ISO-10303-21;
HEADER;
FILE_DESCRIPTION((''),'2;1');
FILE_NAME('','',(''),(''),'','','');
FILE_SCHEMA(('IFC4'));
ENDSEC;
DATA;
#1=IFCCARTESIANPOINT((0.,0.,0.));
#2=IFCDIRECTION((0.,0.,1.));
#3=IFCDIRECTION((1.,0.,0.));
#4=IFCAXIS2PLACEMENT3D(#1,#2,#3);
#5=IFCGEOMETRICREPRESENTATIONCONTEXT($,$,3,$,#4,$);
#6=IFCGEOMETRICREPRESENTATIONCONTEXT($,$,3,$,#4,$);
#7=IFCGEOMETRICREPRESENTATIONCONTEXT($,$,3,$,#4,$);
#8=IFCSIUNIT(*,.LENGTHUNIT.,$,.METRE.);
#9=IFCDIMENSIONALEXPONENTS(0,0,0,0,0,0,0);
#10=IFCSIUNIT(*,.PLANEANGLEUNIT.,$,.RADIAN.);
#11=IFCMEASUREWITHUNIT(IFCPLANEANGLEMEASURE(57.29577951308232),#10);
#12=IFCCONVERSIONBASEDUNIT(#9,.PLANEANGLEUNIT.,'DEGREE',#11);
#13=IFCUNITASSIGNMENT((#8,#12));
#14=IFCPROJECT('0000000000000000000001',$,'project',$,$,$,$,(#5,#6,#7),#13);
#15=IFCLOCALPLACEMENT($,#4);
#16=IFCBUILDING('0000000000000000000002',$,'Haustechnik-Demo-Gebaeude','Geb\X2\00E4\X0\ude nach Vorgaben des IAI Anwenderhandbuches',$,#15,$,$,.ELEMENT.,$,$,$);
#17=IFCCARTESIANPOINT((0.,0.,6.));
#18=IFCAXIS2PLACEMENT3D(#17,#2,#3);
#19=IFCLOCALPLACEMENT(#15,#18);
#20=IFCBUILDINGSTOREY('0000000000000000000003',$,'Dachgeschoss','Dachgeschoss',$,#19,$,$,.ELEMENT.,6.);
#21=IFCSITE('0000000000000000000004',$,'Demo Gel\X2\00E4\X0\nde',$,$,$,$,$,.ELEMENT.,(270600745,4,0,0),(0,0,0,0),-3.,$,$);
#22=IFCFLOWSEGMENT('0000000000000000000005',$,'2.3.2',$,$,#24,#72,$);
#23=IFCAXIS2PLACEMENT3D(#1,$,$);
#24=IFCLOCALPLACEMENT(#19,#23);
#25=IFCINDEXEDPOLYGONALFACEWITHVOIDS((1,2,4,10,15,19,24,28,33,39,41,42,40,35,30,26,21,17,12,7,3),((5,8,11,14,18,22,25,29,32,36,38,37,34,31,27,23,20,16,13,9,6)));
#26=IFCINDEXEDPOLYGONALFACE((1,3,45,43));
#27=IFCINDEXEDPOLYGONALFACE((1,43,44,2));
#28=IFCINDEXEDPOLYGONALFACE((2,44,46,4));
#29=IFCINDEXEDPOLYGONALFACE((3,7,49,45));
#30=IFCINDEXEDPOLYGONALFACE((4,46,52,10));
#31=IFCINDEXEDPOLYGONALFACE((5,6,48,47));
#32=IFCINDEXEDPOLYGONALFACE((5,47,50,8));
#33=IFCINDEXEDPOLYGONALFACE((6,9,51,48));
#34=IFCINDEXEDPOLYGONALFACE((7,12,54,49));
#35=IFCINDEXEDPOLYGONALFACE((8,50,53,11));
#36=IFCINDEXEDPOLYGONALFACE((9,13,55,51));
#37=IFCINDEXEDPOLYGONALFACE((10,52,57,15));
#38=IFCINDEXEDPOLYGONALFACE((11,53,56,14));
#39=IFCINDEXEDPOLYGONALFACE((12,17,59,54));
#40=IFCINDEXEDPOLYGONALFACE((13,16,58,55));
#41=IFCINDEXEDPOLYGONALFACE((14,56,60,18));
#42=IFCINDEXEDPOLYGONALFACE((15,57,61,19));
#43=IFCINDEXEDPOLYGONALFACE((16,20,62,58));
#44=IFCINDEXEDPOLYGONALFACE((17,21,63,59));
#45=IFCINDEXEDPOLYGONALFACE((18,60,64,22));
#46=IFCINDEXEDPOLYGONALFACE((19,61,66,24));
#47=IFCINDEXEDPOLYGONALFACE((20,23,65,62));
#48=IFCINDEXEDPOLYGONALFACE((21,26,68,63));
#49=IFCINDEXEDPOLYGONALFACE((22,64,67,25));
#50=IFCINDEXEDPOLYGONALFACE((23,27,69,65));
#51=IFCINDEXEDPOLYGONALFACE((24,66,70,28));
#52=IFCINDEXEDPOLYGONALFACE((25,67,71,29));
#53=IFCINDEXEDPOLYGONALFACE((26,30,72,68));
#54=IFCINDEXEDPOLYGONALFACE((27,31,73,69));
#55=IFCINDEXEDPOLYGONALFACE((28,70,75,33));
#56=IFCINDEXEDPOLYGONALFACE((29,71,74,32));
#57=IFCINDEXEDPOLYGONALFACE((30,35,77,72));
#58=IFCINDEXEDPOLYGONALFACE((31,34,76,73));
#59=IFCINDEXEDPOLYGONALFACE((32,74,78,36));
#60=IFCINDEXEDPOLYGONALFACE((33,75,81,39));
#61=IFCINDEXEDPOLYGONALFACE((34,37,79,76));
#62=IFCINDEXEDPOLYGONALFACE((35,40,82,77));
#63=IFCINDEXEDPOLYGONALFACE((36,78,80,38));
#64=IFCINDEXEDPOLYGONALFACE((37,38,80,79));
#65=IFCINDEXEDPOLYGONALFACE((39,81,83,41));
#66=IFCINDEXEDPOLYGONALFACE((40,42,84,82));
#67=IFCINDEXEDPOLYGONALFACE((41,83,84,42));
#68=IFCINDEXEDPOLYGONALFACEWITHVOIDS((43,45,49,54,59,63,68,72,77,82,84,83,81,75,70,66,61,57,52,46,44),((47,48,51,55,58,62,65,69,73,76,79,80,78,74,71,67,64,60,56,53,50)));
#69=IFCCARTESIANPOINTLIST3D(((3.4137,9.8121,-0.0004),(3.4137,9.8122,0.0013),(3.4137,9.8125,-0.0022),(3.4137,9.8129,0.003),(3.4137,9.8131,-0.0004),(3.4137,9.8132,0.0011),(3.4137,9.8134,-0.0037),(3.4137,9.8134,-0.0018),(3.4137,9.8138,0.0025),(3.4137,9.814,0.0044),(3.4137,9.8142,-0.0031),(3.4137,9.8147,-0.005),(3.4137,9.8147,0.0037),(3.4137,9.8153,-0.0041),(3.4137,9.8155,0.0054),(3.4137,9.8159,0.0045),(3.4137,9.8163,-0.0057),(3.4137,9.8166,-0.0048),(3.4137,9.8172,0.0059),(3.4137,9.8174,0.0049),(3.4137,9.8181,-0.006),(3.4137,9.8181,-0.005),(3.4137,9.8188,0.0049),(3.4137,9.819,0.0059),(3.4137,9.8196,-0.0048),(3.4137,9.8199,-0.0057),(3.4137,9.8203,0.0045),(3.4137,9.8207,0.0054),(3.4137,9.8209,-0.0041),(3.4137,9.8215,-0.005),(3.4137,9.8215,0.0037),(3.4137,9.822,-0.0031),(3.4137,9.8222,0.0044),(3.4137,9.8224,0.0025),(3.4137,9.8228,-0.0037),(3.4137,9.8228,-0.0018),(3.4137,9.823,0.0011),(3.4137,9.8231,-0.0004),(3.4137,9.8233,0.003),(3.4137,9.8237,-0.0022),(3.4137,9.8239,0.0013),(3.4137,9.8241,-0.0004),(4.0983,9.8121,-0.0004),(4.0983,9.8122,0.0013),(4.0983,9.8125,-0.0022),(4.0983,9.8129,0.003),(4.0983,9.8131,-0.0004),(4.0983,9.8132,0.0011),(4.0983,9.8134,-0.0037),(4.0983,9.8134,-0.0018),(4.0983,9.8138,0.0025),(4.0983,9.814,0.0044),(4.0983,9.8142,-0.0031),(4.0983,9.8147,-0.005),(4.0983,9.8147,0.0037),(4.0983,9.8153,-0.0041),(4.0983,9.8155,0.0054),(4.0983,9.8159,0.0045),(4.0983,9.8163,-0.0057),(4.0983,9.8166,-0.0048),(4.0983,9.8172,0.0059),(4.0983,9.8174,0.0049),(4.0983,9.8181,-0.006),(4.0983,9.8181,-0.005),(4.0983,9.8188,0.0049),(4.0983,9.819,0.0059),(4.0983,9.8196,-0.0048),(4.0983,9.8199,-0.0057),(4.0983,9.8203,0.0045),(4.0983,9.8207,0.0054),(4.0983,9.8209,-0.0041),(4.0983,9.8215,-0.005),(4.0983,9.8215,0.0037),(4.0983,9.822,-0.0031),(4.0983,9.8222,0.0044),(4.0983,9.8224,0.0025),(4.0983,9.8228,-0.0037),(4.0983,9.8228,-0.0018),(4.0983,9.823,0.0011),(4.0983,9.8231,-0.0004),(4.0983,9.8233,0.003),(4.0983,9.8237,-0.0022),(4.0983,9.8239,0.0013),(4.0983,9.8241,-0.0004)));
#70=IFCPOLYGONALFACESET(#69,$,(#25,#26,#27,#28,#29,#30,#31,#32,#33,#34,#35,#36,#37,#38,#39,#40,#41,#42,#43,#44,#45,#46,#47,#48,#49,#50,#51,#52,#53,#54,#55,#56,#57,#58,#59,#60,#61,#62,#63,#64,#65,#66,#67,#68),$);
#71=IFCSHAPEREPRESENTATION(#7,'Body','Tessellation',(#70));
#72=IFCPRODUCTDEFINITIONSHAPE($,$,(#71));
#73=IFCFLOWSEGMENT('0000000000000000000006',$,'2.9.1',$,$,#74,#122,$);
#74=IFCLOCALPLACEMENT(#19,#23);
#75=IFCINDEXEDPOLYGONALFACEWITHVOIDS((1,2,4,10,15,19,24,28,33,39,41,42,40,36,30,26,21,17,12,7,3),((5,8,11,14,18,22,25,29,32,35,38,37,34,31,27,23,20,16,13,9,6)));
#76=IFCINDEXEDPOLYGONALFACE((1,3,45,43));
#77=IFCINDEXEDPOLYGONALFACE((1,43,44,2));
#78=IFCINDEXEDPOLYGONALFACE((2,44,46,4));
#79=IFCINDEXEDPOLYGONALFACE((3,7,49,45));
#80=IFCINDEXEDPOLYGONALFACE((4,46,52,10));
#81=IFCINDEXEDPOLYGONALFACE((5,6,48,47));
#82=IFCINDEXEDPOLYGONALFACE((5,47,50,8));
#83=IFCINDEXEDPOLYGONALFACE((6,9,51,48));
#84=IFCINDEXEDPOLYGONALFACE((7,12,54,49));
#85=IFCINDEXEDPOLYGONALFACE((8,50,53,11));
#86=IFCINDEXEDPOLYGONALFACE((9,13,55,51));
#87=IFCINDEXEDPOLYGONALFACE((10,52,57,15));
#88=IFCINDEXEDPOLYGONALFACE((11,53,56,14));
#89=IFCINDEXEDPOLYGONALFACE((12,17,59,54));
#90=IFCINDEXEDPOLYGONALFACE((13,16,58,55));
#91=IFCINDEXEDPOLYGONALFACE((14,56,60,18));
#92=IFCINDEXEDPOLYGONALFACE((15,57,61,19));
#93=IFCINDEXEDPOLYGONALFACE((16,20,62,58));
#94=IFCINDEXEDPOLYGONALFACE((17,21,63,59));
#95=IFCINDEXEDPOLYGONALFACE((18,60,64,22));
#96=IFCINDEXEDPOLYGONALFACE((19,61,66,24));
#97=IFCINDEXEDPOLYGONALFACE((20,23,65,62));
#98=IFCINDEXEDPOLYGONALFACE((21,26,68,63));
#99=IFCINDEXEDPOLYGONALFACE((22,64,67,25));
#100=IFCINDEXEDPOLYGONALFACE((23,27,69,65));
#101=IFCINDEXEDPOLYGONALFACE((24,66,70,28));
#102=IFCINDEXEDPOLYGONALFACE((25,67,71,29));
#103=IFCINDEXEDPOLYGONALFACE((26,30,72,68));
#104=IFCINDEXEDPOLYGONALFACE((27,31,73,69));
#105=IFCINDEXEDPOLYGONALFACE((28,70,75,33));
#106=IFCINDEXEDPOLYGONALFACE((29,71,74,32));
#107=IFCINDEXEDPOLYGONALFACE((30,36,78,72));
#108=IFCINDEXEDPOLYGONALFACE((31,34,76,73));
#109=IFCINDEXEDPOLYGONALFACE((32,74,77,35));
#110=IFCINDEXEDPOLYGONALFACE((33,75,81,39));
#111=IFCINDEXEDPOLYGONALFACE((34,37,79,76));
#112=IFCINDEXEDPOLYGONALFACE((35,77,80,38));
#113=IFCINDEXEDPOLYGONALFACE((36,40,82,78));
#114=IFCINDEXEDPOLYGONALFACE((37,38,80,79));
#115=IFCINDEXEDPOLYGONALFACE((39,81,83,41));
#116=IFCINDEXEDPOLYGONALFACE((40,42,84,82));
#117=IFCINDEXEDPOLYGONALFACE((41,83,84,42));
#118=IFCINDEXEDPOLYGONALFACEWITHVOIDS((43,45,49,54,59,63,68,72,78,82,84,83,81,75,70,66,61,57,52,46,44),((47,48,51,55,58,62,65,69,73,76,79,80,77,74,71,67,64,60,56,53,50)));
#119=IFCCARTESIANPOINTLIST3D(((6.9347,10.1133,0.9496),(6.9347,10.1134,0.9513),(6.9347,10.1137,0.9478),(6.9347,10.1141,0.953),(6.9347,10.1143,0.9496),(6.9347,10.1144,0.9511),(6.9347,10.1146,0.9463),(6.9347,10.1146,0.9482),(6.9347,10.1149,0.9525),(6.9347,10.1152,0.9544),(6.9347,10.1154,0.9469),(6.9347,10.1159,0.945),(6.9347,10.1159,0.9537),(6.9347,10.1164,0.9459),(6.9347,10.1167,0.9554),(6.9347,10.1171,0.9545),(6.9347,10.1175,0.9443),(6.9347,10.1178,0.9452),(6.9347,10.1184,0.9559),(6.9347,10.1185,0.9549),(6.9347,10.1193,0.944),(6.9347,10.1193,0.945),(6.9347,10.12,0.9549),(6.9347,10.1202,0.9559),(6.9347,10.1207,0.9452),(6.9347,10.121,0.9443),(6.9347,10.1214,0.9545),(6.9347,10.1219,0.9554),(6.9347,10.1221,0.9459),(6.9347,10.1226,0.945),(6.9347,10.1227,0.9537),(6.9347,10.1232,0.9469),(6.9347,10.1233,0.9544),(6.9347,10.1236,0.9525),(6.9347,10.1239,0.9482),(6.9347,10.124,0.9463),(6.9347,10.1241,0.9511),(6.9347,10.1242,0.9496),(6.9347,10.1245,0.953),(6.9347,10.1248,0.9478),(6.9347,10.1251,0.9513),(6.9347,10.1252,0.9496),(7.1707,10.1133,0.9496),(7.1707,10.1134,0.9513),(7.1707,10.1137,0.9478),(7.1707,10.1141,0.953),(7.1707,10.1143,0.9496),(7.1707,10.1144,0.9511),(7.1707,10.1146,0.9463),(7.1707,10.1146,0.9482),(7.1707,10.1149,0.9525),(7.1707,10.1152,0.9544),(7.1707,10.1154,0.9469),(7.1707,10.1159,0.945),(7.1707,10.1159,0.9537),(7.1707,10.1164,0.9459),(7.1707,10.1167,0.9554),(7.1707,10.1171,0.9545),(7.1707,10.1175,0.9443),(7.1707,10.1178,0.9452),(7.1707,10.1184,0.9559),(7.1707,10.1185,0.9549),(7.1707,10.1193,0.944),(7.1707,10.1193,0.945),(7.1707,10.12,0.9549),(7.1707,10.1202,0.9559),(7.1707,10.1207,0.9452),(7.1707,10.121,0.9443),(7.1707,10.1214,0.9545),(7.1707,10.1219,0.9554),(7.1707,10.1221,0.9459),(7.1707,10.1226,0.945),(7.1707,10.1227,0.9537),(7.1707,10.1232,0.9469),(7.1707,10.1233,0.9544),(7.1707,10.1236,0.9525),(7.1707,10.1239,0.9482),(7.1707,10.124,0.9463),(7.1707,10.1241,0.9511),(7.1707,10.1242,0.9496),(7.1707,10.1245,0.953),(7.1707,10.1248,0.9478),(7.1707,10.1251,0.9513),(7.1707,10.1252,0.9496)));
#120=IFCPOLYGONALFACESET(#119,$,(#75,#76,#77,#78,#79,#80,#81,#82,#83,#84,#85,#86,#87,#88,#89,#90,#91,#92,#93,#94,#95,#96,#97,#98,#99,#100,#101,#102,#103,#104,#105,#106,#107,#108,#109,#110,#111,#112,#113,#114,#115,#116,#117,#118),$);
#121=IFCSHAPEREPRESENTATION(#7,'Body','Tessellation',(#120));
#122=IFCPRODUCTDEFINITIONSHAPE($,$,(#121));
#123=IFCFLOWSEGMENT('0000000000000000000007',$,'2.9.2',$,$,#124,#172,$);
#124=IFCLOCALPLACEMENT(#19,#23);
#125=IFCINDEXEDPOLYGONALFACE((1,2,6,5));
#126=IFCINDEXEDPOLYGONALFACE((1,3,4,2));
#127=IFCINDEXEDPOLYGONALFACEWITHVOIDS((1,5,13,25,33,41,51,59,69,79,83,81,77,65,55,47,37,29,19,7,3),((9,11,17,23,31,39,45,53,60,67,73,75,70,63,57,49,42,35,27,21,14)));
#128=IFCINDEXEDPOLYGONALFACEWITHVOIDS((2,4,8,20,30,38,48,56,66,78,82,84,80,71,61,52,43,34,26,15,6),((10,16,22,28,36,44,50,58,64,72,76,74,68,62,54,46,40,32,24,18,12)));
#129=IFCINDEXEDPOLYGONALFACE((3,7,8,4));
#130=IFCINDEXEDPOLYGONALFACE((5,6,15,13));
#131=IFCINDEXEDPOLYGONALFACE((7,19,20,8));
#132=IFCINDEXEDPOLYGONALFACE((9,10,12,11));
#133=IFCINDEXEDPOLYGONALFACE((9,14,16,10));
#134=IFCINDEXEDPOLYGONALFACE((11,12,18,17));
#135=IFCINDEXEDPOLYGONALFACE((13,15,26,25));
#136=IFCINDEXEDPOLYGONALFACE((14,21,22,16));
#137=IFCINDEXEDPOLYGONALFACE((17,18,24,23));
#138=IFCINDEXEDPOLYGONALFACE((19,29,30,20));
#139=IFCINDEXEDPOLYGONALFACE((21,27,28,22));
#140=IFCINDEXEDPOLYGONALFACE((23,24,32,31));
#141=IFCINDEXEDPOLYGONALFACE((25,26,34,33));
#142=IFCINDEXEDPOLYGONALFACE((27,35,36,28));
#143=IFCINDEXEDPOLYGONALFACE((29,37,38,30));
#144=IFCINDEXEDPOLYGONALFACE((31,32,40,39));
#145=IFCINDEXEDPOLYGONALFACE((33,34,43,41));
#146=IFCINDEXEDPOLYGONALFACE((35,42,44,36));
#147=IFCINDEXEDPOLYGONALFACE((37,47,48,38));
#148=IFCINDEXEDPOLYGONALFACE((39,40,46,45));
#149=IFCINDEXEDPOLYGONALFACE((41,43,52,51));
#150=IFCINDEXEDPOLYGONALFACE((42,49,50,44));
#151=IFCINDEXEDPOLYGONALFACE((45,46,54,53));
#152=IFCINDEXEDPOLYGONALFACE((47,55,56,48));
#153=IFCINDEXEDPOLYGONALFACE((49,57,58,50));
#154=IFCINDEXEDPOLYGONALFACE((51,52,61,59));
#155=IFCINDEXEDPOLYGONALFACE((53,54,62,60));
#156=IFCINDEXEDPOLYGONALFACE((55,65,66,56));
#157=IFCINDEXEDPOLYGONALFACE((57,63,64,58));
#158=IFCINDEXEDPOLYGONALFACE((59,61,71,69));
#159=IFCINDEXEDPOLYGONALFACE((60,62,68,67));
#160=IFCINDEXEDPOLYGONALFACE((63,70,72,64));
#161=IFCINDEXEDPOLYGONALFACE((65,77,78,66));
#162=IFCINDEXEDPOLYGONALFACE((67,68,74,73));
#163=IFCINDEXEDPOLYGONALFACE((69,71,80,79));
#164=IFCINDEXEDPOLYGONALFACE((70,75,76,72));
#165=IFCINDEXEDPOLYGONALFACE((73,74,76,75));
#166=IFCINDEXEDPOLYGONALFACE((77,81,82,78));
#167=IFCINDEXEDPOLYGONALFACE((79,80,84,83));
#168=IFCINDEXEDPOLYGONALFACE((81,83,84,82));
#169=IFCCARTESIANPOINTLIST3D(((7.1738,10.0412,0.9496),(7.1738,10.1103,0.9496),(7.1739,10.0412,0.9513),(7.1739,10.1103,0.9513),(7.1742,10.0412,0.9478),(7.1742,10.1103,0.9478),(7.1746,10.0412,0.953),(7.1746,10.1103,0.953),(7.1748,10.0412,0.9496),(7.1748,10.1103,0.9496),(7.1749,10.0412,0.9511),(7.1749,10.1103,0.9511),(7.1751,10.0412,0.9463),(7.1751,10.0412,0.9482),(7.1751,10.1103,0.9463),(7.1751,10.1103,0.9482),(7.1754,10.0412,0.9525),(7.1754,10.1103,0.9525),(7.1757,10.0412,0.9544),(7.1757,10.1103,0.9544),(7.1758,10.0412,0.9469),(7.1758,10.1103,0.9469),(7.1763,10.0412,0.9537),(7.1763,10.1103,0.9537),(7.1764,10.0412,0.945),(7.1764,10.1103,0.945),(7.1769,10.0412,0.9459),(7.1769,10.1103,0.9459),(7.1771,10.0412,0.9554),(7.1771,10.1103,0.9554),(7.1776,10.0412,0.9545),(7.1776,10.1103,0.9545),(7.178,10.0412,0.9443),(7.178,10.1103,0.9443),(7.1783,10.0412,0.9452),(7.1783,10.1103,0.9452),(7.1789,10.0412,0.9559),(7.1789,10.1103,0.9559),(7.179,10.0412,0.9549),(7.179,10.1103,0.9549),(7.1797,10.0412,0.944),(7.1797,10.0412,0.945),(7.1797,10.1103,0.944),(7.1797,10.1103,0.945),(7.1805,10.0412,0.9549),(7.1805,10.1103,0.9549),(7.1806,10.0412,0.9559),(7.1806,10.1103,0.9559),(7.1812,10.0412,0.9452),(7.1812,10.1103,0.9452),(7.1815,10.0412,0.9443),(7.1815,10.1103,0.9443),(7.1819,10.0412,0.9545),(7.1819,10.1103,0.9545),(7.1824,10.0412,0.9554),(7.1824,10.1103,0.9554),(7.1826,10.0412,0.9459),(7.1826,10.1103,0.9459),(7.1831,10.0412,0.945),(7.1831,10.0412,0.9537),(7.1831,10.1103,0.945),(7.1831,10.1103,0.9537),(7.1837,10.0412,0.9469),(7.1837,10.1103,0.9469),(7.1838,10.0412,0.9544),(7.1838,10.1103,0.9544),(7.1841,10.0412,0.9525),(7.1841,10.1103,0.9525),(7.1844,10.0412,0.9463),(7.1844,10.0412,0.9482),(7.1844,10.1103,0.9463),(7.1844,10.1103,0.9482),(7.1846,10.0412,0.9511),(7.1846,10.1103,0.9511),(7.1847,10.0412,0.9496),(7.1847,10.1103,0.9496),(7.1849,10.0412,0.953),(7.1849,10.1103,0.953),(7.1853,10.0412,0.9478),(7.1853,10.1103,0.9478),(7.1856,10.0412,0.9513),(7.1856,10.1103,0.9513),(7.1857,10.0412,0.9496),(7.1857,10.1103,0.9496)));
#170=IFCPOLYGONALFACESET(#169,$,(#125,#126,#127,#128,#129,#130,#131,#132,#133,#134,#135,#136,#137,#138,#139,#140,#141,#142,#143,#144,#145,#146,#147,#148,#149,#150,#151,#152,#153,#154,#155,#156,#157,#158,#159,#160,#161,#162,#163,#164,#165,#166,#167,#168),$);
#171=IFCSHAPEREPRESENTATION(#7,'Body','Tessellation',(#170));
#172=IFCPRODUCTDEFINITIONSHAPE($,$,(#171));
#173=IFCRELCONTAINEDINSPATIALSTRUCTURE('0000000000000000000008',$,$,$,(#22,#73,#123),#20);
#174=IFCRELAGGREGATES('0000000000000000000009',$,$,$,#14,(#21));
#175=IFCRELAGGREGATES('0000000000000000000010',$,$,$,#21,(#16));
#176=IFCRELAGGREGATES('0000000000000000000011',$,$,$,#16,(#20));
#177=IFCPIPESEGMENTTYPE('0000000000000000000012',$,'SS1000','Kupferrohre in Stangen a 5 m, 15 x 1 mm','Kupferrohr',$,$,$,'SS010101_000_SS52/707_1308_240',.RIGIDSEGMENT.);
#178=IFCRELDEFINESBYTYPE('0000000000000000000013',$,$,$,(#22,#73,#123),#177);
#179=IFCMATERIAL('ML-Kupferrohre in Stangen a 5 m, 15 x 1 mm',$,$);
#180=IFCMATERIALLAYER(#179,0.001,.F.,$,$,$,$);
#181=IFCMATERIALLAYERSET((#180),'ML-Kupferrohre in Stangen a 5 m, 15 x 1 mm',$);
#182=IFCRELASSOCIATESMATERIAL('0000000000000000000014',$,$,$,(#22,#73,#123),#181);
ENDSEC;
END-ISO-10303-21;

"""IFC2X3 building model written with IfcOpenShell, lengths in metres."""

from ifc_helpers import new_model, entity, si_unit, converted_unit, frame, origin_with_axes, origin_2d_with_axis, place, context, project, spatial, hollow_circle, extrude, material, layer, layer_set, layer_usage, type_object, element, save


model = new_model("IFC2X3")

# Units and contexts
context_of_model_1 = context(None, 3, world=origin_with_axes())
context_of_model_2 = context(None, 3, world=origin_with_axes())
context_of_model_3 = context(None, 3, world=origin_with_axes())
ifc_project = project(units=[si_unit("LENGTHUNIT", "METRE"), converted_unit("PLANEANGLEUNIT", "DEGREE", entity("IfcPlaneAngleMeasure", 57.29577951308232), si_unit("PLANEANGLEUNIT", "RADIAN"), dimensions=[0, 0, 0, 0, 0, 0, 0])], contexts=[context_of_model_1, context_of_model_2, context_of_model_3])

# Site, building, storey
site = spatial("IfcSite", under=ifc_project, Name="Demo Gelände", CompositionType="ELEMENT", RefLatitude=(270600745, 4, 0, 0), RefLongitude=(0, 0, 0, 0), RefElevation=-3.0)
building_placement = place(None, origin_with_axes())
building = spatial("IfcBuilding", under=site, at=building_placement, Name="Haustechnik-Demo-Gebaeude", Description="Gebäude nach Vorgaben des IAI Anwenderhandbuches", CompositionType="ELEMENT")
storey_placement = place(building_placement, frame((0.0, 0.0, 6.0), z_axis=(0.0, 0.0, 1.0), x_axis=(1.0, 0.0, 0.0)))
storey = spatial("IfcBuildingStorey", under=building, at=storey_placement, Name="Dachgeschoss", Description="Dachgeschoss", CompositionType="ELEMENT", Elevation=6.0)

# Flow segments
ifc_material = material(Name="ML-Kupferrohre in Stangen a 5 m, 15 x 1 mm")
ifc_layer = layer(ifc_material, 0.001, ventilated=False)
ifc_layer_set = layer_set([ifc_layer], Name="ML-Kupferrohre in Stangen a 5 m, 15 x 1 mm")
ifc_layer_usage = layer_usage(ifc_layer_set, "AXIS2", "POSITIVE", 0.0)
pipe_segment_type_1 = type_object("IfcPipeSegmentType", Name="SS1000", Description="Kupferrohre in Stangen a 5 m, 15 x 1 mm", ApplicableOccurrence="Kupferrohr", ElementType="SS010101_000_SS52/707_1308_240", PredefinedType="RIGIDSEGMENT")
flow_segment_1_placement = place(storey_placement, frame((4.0983, 9.8181, 0.0), z_axis=(-1.0, 0.0, 0.0), x_axis=(0.0, 0.0, -1.0)))
element("IfcFlowSegment", 1, at=flow_segment_1_placement, inside=storey, type_object=pipe_segment_type_1, material=ifc_layer_usage, Name="2.3.2", context=context_of_model_3, shape_type="SweptSolid", body=[
    extrude(hollow_circle(Radius=0.006, WallThickness=0.001, at=origin_2d_with_axis()), origin_with_axes(), (0.0, 0.0, 1.0), 0.6846),
])
flow_segment_2_placement = place(storey_placement, frame((6.9347, 10.1193, 0.95), z_axis=(1.0, 0.0, 0.0), x_axis=(0.0, 0.0, -1.0)))
element("IfcFlowSegment", 2, at=flow_segment_2_placement, inside=storey, type_object=pipe_segment_type_1, material=ifc_layer_usage, Name="2.9.1", context=context_of_model_3, shape_type="SweptSolid", body=[
    extrude(hollow_circle(Radius=0.006, WallThickness=0.001, at=origin_2d_with_axis()), origin_with_axes(), (0.0, 0.0, 1.0), 0.236),
])
flow_segment_3_placement = place(storey_placement, frame((7.1797, 10.1103, 0.95), z_axis=(0.0, -1.0, 0.0), x_axis=(0.0, 0.0, -1.0)))
element("IfcFlowSegment", 3, at=flow_segment_3_placement, inside=storey, type_object=pipe_segment_type_1, material=ifc_layer_usage, Name="2.9.2", context=context_of_model_3, shape_type="SweptSolid", body=[
    extrude(hollow_circle(Radius=0.006, WallThickness=0.001, at=origin_2d_with_axis()), origin_with_axes(), (0.0, 0.0, 1.0), 0.0691),
])

save(model, "model.ifc")
